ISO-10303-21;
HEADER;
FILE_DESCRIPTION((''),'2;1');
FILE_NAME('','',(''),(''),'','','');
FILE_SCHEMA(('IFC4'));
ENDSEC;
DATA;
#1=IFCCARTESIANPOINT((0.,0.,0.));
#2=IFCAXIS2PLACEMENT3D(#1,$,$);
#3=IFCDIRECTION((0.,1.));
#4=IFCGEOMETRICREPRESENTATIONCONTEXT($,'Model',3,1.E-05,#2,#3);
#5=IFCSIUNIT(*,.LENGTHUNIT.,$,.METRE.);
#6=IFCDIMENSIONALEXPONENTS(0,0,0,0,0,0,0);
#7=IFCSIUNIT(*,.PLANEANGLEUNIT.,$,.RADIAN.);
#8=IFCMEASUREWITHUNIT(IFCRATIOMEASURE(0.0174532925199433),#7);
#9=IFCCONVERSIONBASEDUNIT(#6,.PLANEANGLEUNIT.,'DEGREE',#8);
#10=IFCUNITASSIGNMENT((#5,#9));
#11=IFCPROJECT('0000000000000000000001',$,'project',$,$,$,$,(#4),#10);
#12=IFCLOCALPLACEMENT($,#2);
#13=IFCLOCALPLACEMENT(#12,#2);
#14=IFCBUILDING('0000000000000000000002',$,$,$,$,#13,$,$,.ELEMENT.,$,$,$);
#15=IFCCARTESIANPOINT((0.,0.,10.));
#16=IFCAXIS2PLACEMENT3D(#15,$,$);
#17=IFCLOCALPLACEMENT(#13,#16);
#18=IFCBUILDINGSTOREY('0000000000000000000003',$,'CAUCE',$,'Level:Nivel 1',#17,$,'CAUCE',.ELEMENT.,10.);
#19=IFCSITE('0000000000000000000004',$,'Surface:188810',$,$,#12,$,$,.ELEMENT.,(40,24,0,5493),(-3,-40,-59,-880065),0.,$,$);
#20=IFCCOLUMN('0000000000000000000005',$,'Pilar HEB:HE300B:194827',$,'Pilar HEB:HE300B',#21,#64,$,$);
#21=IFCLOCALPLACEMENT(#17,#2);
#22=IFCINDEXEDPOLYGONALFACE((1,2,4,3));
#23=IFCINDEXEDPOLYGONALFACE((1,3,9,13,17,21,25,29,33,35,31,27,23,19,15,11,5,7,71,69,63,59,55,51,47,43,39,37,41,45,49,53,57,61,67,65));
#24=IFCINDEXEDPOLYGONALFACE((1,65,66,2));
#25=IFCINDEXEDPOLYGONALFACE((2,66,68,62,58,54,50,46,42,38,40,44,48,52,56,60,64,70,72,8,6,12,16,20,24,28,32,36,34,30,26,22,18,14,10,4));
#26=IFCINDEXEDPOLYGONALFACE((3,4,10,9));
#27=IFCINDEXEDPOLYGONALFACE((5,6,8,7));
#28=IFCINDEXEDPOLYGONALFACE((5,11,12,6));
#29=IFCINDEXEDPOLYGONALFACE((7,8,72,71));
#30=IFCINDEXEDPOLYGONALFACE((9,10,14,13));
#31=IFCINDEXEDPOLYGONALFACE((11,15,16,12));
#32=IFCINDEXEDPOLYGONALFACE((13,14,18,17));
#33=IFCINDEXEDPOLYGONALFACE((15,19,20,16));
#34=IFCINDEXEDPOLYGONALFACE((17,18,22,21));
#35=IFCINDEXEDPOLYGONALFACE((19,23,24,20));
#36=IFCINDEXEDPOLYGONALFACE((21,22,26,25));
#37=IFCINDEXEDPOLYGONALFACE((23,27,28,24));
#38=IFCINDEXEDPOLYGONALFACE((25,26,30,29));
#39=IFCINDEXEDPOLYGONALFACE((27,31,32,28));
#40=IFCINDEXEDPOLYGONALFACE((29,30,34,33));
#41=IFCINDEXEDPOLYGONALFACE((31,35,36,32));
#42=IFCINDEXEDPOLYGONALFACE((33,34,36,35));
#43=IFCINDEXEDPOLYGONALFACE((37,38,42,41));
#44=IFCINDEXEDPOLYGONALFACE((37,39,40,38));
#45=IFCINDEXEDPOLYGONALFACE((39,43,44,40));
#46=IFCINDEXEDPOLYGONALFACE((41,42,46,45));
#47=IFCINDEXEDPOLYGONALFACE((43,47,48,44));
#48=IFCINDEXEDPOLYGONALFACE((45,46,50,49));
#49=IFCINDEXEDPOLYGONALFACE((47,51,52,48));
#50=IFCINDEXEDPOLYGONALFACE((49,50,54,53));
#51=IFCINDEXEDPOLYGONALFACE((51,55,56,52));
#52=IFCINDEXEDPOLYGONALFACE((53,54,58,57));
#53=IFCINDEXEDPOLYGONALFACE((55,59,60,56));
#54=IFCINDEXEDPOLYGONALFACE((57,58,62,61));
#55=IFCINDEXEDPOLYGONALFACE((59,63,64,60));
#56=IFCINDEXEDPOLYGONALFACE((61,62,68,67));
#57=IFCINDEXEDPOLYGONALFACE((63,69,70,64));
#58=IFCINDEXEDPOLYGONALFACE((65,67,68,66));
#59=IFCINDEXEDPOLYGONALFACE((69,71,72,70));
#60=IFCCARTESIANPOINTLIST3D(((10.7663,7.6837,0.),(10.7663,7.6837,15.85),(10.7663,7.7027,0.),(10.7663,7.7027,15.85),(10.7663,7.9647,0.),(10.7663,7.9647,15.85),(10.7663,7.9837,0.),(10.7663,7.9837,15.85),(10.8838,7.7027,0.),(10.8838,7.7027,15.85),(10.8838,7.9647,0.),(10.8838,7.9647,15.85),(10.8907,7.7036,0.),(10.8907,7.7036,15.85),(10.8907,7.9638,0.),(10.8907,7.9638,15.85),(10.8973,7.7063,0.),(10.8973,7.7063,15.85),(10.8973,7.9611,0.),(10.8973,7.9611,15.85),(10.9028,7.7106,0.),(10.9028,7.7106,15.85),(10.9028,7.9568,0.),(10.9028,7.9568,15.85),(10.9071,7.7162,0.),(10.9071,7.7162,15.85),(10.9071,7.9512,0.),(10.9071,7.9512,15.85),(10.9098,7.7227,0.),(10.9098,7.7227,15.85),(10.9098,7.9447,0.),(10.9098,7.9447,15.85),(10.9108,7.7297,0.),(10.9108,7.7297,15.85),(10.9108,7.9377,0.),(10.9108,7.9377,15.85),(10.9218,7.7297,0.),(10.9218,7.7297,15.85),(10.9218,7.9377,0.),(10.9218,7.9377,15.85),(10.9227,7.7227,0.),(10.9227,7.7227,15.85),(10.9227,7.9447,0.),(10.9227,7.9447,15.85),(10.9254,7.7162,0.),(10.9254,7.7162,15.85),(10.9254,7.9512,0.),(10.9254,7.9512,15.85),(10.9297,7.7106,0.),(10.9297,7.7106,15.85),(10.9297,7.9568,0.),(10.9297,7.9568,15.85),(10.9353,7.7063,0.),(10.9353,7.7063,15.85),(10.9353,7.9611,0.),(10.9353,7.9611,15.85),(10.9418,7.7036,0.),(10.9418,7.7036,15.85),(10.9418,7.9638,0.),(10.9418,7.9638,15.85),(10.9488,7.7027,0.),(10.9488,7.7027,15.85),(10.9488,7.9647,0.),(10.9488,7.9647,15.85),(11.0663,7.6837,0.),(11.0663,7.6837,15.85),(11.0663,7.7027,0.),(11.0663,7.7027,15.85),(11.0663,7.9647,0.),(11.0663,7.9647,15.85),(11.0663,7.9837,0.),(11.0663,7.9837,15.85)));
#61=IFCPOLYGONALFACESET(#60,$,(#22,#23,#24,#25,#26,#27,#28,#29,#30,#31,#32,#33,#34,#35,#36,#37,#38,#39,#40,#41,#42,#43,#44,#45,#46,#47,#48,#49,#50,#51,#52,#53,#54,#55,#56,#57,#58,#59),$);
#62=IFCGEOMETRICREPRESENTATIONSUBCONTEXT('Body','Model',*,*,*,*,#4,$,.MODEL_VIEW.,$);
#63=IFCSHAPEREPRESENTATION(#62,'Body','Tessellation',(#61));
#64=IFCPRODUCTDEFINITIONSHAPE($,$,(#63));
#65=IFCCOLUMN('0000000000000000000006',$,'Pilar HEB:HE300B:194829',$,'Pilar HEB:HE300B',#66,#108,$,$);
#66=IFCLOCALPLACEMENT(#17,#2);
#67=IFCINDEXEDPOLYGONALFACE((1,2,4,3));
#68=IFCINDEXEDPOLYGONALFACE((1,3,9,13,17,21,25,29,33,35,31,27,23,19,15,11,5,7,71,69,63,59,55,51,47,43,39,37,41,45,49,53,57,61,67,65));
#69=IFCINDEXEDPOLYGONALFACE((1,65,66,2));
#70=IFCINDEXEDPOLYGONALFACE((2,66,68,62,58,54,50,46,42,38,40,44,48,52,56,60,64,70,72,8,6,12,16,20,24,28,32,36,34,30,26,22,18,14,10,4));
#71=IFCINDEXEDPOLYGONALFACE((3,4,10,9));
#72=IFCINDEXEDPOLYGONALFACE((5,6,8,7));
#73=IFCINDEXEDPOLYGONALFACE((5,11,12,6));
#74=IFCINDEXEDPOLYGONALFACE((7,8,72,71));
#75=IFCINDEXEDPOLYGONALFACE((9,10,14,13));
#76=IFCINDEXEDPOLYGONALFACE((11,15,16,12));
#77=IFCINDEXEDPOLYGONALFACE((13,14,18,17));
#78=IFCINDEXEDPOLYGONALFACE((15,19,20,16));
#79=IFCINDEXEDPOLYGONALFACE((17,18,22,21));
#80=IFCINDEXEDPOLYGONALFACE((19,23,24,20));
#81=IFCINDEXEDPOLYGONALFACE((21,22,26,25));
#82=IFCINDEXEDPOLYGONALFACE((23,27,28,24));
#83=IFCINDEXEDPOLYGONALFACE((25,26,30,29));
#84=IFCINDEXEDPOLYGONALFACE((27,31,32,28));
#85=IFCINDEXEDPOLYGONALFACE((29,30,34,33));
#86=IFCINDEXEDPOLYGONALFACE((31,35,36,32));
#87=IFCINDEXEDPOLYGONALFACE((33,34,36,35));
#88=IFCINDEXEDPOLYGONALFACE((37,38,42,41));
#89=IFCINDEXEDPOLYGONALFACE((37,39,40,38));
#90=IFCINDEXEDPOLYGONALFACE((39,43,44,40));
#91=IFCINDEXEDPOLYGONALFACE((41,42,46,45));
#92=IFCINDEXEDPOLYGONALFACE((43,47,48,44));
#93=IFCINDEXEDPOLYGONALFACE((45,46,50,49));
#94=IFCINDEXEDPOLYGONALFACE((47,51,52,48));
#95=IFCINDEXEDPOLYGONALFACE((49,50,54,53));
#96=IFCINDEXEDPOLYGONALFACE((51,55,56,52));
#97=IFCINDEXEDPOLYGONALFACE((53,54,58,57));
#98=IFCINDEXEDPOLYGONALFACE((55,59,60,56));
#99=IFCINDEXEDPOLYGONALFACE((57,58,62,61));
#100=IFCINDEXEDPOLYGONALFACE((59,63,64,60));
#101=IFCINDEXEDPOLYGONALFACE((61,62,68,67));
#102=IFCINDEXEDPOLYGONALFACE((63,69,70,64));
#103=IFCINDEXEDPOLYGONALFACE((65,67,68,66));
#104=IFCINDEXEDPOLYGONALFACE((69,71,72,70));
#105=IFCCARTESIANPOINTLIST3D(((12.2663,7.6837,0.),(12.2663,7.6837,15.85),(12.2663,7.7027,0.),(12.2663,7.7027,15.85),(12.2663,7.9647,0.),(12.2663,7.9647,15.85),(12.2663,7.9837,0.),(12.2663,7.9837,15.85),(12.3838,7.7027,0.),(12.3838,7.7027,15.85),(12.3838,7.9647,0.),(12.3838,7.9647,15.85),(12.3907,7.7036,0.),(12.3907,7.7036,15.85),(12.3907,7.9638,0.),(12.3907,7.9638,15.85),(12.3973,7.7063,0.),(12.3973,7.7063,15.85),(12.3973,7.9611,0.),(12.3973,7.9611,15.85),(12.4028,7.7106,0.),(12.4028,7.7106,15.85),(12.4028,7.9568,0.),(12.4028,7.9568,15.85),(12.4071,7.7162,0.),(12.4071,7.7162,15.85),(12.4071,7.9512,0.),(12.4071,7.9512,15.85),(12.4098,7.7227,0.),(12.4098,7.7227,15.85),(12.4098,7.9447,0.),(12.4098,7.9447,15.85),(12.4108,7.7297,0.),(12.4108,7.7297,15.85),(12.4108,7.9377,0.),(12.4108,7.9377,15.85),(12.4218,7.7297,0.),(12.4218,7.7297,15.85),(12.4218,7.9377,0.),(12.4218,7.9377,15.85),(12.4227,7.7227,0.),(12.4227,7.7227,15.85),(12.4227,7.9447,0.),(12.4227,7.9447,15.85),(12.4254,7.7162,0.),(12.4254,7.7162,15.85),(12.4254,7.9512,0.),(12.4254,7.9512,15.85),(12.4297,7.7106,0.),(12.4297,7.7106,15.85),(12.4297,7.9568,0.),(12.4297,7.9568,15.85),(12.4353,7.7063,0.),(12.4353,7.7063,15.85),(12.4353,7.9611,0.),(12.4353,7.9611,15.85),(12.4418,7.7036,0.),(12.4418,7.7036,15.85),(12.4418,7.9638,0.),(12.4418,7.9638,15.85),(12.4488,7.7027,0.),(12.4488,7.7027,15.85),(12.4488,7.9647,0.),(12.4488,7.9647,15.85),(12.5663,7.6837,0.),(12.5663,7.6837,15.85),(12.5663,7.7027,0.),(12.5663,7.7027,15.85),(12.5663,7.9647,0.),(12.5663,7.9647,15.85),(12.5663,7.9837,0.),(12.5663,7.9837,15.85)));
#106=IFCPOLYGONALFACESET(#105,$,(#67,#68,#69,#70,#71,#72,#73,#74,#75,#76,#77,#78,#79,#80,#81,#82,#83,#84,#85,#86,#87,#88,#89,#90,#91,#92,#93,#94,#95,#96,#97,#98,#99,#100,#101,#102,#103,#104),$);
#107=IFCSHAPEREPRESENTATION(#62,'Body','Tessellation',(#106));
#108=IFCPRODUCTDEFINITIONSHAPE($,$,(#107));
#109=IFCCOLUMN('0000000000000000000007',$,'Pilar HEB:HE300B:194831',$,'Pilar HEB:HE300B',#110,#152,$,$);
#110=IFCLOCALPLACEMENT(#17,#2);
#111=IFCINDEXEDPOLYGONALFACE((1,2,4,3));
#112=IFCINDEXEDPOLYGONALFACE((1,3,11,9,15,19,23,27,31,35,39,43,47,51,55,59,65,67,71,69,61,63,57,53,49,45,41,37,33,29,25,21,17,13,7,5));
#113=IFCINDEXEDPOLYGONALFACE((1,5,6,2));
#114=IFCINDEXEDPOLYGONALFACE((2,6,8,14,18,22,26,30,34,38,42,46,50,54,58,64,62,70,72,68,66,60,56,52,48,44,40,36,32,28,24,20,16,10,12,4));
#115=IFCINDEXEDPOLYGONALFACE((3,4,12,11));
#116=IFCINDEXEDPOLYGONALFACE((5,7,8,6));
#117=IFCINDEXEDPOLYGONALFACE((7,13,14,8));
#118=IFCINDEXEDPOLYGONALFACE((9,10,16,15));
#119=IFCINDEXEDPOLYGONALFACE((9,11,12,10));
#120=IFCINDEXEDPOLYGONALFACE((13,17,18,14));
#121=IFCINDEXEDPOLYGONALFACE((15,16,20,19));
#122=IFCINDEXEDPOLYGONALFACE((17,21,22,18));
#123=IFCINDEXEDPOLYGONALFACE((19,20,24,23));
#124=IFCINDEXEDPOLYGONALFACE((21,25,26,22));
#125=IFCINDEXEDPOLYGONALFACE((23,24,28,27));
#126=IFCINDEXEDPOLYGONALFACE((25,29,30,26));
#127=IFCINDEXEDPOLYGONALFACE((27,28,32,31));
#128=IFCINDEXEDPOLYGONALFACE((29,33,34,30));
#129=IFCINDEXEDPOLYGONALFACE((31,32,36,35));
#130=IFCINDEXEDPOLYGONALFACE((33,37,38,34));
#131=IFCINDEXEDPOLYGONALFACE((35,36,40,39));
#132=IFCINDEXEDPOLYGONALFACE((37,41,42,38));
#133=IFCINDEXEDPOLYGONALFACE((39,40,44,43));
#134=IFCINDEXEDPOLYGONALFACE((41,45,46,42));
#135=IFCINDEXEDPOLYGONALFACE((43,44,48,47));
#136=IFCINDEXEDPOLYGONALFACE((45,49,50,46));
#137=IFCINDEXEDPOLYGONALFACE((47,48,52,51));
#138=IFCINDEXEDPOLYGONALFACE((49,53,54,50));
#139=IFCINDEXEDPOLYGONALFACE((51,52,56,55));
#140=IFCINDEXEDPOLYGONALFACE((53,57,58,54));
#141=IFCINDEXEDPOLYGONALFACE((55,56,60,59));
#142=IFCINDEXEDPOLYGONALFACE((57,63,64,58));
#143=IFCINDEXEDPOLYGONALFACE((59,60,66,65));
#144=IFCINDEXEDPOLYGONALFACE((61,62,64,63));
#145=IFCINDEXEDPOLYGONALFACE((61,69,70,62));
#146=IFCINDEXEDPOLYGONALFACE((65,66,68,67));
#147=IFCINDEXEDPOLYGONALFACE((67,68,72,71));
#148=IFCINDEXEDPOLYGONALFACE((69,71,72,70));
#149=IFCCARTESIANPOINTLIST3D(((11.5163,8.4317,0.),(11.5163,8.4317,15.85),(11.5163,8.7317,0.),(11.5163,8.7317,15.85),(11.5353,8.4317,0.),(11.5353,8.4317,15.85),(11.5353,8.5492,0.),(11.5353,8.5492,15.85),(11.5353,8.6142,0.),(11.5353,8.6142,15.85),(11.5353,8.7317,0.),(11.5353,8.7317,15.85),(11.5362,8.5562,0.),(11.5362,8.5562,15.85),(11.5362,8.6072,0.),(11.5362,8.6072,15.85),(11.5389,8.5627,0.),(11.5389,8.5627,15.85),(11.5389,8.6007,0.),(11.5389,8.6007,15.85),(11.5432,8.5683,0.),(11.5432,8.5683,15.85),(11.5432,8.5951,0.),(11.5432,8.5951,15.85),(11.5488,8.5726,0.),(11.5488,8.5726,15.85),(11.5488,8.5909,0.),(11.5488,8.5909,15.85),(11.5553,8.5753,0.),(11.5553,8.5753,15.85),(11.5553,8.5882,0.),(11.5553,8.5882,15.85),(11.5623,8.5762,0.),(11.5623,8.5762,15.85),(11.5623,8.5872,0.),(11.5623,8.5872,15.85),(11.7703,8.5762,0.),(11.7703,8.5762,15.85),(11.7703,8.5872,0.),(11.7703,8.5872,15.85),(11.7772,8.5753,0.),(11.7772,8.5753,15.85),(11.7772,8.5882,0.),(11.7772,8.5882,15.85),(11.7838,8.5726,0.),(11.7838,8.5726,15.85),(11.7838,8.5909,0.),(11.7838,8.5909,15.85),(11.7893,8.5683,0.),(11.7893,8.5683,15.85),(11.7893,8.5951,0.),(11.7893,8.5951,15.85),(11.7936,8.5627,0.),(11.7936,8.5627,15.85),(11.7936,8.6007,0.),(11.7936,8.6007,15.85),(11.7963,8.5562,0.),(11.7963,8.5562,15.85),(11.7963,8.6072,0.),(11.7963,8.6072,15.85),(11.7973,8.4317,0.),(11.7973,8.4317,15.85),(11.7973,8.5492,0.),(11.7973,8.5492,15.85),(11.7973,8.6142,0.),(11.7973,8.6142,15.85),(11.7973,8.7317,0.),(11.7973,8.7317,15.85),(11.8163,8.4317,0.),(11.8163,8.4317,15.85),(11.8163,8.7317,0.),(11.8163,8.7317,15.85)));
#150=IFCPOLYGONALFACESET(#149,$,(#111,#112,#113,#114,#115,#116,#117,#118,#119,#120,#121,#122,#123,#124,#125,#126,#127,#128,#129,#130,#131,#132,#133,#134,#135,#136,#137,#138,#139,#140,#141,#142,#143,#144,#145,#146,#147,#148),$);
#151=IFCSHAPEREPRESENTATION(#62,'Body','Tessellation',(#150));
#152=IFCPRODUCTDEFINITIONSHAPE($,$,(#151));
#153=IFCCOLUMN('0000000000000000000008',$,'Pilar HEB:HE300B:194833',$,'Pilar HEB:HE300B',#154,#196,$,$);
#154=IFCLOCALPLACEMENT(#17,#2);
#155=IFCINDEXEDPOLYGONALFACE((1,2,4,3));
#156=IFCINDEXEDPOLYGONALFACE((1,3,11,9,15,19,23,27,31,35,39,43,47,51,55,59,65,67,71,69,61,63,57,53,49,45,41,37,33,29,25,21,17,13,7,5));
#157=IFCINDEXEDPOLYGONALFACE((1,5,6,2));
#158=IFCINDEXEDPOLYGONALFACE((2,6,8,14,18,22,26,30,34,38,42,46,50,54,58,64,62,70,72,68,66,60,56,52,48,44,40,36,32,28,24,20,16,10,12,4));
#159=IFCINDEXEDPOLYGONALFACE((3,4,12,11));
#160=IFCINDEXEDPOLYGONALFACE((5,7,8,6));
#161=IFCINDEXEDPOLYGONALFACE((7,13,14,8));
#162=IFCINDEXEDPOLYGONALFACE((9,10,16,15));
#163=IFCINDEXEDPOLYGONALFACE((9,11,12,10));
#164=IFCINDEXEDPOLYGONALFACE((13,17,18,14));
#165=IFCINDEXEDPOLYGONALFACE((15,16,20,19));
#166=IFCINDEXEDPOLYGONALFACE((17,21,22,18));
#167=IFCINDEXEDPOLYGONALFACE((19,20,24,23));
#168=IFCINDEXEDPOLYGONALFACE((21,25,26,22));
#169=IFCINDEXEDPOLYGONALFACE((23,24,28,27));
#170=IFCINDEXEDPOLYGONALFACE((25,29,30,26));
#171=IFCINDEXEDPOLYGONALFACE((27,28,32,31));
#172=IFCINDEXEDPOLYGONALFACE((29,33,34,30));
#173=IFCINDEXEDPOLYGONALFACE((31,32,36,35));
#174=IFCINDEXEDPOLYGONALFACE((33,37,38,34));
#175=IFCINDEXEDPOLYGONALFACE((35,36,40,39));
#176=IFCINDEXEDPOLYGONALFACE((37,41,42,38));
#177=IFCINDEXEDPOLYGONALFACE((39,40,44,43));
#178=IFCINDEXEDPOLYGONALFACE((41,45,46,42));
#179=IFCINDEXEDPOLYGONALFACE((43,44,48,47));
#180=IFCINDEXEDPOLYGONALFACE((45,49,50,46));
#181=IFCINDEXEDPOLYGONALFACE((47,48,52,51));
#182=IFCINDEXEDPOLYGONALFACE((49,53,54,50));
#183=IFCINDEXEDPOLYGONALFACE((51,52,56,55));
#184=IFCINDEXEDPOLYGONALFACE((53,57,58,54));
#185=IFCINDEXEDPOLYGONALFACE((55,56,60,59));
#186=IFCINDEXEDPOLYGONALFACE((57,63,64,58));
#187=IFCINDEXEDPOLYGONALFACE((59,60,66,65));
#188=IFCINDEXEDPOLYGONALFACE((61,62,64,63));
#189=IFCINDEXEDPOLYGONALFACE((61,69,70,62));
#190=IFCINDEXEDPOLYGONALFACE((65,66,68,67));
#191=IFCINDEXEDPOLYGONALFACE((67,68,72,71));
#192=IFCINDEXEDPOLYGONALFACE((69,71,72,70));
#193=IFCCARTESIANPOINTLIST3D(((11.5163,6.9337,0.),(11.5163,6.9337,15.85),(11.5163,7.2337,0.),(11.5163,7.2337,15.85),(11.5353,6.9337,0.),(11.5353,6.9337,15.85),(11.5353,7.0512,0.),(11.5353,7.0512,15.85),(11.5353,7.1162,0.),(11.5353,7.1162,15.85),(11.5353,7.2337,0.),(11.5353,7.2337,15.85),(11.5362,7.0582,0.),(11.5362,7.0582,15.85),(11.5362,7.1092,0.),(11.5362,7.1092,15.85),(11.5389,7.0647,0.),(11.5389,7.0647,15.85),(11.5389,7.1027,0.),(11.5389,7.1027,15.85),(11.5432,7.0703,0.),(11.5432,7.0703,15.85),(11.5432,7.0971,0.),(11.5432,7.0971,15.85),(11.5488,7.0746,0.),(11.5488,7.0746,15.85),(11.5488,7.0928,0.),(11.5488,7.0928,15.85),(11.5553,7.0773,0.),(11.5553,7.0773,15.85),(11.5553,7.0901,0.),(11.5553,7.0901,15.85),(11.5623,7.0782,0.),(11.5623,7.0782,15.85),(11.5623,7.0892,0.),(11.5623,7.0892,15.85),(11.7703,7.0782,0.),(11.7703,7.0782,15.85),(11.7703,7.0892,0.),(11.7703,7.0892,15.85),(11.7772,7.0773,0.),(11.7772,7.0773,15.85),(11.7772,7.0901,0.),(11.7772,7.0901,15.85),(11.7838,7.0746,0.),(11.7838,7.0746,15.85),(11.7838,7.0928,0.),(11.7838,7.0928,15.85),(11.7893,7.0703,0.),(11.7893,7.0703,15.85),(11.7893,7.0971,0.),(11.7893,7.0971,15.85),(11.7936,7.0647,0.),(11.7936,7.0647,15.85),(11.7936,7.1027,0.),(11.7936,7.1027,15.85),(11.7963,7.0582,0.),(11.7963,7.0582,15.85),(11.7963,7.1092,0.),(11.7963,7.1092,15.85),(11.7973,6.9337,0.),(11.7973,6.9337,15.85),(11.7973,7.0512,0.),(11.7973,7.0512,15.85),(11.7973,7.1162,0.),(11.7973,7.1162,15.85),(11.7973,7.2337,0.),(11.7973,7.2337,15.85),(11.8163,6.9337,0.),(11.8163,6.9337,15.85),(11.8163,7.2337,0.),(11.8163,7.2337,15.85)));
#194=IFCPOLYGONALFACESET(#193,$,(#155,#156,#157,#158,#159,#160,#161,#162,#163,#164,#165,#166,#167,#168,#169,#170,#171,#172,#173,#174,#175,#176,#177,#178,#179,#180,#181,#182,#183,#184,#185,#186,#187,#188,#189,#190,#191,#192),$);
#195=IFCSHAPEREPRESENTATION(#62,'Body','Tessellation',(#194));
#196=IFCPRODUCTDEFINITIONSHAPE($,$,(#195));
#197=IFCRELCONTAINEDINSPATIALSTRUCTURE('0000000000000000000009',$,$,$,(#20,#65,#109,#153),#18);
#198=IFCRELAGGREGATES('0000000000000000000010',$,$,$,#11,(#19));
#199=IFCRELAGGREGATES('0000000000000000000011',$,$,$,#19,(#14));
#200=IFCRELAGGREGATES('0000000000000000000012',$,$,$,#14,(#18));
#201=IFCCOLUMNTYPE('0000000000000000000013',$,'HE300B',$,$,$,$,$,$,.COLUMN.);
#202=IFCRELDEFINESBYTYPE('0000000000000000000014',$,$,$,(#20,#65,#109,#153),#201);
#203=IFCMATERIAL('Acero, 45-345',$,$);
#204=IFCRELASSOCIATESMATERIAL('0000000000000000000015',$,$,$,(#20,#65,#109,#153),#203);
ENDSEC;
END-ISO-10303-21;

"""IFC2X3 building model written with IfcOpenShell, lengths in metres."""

from ifc_helpers import new_model, entity, si_unit, converted_unit, direction, frame, frame_2d, origin, place, context, subcontext, project, spatial, i_section, extrude, source, transform, mapped, material, type_object, type_shapes, element, save


model = new_model("IFC2X3")

# Units and contexts
model_context = context("Model", 3, precision=1e-05, world=origin(), true_north=direction((0.0, 1.0)))
body_context = subcontext(model_context, "Body", "Model", "MODEL_VIEW")
ifc_project = project(units=[si_unit("LENGTHUNIT", "METRE"), converted_unit("PLANEANGLEUNIT", "DEGREE", entity("IfcRatioMeasure", 0.0174532925199433), si_unit("PLANEANGLEUNIT", "RADIAN"), dimensions=[0, 0, 0, 0, 0, 0, 0])], contexts=[model_context])

# Site, building, storey
site_placement = place(None, origin())
site = spatial("IfcSite", under=ifc_project, at=site_placement, Name="Surface:188810", CompositionType="ELEMENT", RefLatitude=(40, 24, 0, 5493), RefLongitude=(-3, -40, -59, -880065), RefElevation=0.0)
building_placement = place(site_placement, origin())
building = spatial("IfcBuilding", under=site, at=building_placement, CompositionType="ELEMENT")
storey_placement = place(building_placement, frame((0.0, 0.0, 10.0)))
storey = spatial("IfcBuildingStorey", under=building, at=storey_placement, Name="CAUCE", ObjectType="Level:Nivel 1", LongName="CAUCE", CompositionType="ELEMENT", Elevation=10.0)

# Columns
ifc_material_1 = material(Name="Acero, 45-345")
column_type_1 = type_object("IfcColumnType", Name="HE300B", PredefinedType="COLUMN")
shared_shape_1 = source(origin(), body_context, "Body", "SweptSolid", [
    extrude(i_section(OverallWidth=0.3, OverallDepth=0.3, WebThickness=0.011, FlangeThickness=0.019, FilletRadius=0.027, at=frame_2d((0.0, 0.0), x_axis=(0.0, 1.0))), frame((0.0, 0.0, 10.0), z_axis=(0.0, 0.0, 1.0), x_axis=(0.0, -1.0, 0.0)), (0.0, 0.0, 1.0), 15.85),
])
type_shapes(column_type_1, [shared_shape_1])
for number, where, name in (
    (1, (10.9163, 7.8337, -10.0), "Pilar HEB:HE300B:194827"),
    (2, (12.4163, 7.8337, -10.0), "Pilar HEB:HE300B:194829"),
):
    element("IfcColumn", number, at=place(storey_placement, frame(where)), inside=storey, type_object=column_type_1, material=ifc_material_1, Name=name, ObjectType="Pilar HEB:HE300B", context=body_context, shape_type="MappedRepresentation", body=[
        mapped(shared_shape_1, transform((0.0, 0.0, 0.0), scale=1.0)),
    ])
for number, where, z_axis, x_axis, name in (
    (3, (11.6663, 8.5817, -10.0), (0.0, 0.0, 1.0), (0.0, 1.0, 0.0), "Pilar HEB:HE300B:194831"),
    (4, (11.6663, 7.0837, -10.0), (0.0, 0.0, 1.0), (0.0, 1.0, 0.0), "Pilar HEB:HE300B:194833"),
):
    element("IfcColumn", number, at=place(storey_placement, frame(where, z_axis=z_axis, x_axis=x_axis)), inside=storey, type_object=column_type_1, material=ifc_material_1, Name=name, ObjectType="Pilar HEB:HE300B", context=body_context, shape_type="MappedRepresentation", body=[
        mapped(shared_shape_1, transform((0.0, 0.0, 0.0), scale=1.0)),
    ])

save(model, "model.ifc")
